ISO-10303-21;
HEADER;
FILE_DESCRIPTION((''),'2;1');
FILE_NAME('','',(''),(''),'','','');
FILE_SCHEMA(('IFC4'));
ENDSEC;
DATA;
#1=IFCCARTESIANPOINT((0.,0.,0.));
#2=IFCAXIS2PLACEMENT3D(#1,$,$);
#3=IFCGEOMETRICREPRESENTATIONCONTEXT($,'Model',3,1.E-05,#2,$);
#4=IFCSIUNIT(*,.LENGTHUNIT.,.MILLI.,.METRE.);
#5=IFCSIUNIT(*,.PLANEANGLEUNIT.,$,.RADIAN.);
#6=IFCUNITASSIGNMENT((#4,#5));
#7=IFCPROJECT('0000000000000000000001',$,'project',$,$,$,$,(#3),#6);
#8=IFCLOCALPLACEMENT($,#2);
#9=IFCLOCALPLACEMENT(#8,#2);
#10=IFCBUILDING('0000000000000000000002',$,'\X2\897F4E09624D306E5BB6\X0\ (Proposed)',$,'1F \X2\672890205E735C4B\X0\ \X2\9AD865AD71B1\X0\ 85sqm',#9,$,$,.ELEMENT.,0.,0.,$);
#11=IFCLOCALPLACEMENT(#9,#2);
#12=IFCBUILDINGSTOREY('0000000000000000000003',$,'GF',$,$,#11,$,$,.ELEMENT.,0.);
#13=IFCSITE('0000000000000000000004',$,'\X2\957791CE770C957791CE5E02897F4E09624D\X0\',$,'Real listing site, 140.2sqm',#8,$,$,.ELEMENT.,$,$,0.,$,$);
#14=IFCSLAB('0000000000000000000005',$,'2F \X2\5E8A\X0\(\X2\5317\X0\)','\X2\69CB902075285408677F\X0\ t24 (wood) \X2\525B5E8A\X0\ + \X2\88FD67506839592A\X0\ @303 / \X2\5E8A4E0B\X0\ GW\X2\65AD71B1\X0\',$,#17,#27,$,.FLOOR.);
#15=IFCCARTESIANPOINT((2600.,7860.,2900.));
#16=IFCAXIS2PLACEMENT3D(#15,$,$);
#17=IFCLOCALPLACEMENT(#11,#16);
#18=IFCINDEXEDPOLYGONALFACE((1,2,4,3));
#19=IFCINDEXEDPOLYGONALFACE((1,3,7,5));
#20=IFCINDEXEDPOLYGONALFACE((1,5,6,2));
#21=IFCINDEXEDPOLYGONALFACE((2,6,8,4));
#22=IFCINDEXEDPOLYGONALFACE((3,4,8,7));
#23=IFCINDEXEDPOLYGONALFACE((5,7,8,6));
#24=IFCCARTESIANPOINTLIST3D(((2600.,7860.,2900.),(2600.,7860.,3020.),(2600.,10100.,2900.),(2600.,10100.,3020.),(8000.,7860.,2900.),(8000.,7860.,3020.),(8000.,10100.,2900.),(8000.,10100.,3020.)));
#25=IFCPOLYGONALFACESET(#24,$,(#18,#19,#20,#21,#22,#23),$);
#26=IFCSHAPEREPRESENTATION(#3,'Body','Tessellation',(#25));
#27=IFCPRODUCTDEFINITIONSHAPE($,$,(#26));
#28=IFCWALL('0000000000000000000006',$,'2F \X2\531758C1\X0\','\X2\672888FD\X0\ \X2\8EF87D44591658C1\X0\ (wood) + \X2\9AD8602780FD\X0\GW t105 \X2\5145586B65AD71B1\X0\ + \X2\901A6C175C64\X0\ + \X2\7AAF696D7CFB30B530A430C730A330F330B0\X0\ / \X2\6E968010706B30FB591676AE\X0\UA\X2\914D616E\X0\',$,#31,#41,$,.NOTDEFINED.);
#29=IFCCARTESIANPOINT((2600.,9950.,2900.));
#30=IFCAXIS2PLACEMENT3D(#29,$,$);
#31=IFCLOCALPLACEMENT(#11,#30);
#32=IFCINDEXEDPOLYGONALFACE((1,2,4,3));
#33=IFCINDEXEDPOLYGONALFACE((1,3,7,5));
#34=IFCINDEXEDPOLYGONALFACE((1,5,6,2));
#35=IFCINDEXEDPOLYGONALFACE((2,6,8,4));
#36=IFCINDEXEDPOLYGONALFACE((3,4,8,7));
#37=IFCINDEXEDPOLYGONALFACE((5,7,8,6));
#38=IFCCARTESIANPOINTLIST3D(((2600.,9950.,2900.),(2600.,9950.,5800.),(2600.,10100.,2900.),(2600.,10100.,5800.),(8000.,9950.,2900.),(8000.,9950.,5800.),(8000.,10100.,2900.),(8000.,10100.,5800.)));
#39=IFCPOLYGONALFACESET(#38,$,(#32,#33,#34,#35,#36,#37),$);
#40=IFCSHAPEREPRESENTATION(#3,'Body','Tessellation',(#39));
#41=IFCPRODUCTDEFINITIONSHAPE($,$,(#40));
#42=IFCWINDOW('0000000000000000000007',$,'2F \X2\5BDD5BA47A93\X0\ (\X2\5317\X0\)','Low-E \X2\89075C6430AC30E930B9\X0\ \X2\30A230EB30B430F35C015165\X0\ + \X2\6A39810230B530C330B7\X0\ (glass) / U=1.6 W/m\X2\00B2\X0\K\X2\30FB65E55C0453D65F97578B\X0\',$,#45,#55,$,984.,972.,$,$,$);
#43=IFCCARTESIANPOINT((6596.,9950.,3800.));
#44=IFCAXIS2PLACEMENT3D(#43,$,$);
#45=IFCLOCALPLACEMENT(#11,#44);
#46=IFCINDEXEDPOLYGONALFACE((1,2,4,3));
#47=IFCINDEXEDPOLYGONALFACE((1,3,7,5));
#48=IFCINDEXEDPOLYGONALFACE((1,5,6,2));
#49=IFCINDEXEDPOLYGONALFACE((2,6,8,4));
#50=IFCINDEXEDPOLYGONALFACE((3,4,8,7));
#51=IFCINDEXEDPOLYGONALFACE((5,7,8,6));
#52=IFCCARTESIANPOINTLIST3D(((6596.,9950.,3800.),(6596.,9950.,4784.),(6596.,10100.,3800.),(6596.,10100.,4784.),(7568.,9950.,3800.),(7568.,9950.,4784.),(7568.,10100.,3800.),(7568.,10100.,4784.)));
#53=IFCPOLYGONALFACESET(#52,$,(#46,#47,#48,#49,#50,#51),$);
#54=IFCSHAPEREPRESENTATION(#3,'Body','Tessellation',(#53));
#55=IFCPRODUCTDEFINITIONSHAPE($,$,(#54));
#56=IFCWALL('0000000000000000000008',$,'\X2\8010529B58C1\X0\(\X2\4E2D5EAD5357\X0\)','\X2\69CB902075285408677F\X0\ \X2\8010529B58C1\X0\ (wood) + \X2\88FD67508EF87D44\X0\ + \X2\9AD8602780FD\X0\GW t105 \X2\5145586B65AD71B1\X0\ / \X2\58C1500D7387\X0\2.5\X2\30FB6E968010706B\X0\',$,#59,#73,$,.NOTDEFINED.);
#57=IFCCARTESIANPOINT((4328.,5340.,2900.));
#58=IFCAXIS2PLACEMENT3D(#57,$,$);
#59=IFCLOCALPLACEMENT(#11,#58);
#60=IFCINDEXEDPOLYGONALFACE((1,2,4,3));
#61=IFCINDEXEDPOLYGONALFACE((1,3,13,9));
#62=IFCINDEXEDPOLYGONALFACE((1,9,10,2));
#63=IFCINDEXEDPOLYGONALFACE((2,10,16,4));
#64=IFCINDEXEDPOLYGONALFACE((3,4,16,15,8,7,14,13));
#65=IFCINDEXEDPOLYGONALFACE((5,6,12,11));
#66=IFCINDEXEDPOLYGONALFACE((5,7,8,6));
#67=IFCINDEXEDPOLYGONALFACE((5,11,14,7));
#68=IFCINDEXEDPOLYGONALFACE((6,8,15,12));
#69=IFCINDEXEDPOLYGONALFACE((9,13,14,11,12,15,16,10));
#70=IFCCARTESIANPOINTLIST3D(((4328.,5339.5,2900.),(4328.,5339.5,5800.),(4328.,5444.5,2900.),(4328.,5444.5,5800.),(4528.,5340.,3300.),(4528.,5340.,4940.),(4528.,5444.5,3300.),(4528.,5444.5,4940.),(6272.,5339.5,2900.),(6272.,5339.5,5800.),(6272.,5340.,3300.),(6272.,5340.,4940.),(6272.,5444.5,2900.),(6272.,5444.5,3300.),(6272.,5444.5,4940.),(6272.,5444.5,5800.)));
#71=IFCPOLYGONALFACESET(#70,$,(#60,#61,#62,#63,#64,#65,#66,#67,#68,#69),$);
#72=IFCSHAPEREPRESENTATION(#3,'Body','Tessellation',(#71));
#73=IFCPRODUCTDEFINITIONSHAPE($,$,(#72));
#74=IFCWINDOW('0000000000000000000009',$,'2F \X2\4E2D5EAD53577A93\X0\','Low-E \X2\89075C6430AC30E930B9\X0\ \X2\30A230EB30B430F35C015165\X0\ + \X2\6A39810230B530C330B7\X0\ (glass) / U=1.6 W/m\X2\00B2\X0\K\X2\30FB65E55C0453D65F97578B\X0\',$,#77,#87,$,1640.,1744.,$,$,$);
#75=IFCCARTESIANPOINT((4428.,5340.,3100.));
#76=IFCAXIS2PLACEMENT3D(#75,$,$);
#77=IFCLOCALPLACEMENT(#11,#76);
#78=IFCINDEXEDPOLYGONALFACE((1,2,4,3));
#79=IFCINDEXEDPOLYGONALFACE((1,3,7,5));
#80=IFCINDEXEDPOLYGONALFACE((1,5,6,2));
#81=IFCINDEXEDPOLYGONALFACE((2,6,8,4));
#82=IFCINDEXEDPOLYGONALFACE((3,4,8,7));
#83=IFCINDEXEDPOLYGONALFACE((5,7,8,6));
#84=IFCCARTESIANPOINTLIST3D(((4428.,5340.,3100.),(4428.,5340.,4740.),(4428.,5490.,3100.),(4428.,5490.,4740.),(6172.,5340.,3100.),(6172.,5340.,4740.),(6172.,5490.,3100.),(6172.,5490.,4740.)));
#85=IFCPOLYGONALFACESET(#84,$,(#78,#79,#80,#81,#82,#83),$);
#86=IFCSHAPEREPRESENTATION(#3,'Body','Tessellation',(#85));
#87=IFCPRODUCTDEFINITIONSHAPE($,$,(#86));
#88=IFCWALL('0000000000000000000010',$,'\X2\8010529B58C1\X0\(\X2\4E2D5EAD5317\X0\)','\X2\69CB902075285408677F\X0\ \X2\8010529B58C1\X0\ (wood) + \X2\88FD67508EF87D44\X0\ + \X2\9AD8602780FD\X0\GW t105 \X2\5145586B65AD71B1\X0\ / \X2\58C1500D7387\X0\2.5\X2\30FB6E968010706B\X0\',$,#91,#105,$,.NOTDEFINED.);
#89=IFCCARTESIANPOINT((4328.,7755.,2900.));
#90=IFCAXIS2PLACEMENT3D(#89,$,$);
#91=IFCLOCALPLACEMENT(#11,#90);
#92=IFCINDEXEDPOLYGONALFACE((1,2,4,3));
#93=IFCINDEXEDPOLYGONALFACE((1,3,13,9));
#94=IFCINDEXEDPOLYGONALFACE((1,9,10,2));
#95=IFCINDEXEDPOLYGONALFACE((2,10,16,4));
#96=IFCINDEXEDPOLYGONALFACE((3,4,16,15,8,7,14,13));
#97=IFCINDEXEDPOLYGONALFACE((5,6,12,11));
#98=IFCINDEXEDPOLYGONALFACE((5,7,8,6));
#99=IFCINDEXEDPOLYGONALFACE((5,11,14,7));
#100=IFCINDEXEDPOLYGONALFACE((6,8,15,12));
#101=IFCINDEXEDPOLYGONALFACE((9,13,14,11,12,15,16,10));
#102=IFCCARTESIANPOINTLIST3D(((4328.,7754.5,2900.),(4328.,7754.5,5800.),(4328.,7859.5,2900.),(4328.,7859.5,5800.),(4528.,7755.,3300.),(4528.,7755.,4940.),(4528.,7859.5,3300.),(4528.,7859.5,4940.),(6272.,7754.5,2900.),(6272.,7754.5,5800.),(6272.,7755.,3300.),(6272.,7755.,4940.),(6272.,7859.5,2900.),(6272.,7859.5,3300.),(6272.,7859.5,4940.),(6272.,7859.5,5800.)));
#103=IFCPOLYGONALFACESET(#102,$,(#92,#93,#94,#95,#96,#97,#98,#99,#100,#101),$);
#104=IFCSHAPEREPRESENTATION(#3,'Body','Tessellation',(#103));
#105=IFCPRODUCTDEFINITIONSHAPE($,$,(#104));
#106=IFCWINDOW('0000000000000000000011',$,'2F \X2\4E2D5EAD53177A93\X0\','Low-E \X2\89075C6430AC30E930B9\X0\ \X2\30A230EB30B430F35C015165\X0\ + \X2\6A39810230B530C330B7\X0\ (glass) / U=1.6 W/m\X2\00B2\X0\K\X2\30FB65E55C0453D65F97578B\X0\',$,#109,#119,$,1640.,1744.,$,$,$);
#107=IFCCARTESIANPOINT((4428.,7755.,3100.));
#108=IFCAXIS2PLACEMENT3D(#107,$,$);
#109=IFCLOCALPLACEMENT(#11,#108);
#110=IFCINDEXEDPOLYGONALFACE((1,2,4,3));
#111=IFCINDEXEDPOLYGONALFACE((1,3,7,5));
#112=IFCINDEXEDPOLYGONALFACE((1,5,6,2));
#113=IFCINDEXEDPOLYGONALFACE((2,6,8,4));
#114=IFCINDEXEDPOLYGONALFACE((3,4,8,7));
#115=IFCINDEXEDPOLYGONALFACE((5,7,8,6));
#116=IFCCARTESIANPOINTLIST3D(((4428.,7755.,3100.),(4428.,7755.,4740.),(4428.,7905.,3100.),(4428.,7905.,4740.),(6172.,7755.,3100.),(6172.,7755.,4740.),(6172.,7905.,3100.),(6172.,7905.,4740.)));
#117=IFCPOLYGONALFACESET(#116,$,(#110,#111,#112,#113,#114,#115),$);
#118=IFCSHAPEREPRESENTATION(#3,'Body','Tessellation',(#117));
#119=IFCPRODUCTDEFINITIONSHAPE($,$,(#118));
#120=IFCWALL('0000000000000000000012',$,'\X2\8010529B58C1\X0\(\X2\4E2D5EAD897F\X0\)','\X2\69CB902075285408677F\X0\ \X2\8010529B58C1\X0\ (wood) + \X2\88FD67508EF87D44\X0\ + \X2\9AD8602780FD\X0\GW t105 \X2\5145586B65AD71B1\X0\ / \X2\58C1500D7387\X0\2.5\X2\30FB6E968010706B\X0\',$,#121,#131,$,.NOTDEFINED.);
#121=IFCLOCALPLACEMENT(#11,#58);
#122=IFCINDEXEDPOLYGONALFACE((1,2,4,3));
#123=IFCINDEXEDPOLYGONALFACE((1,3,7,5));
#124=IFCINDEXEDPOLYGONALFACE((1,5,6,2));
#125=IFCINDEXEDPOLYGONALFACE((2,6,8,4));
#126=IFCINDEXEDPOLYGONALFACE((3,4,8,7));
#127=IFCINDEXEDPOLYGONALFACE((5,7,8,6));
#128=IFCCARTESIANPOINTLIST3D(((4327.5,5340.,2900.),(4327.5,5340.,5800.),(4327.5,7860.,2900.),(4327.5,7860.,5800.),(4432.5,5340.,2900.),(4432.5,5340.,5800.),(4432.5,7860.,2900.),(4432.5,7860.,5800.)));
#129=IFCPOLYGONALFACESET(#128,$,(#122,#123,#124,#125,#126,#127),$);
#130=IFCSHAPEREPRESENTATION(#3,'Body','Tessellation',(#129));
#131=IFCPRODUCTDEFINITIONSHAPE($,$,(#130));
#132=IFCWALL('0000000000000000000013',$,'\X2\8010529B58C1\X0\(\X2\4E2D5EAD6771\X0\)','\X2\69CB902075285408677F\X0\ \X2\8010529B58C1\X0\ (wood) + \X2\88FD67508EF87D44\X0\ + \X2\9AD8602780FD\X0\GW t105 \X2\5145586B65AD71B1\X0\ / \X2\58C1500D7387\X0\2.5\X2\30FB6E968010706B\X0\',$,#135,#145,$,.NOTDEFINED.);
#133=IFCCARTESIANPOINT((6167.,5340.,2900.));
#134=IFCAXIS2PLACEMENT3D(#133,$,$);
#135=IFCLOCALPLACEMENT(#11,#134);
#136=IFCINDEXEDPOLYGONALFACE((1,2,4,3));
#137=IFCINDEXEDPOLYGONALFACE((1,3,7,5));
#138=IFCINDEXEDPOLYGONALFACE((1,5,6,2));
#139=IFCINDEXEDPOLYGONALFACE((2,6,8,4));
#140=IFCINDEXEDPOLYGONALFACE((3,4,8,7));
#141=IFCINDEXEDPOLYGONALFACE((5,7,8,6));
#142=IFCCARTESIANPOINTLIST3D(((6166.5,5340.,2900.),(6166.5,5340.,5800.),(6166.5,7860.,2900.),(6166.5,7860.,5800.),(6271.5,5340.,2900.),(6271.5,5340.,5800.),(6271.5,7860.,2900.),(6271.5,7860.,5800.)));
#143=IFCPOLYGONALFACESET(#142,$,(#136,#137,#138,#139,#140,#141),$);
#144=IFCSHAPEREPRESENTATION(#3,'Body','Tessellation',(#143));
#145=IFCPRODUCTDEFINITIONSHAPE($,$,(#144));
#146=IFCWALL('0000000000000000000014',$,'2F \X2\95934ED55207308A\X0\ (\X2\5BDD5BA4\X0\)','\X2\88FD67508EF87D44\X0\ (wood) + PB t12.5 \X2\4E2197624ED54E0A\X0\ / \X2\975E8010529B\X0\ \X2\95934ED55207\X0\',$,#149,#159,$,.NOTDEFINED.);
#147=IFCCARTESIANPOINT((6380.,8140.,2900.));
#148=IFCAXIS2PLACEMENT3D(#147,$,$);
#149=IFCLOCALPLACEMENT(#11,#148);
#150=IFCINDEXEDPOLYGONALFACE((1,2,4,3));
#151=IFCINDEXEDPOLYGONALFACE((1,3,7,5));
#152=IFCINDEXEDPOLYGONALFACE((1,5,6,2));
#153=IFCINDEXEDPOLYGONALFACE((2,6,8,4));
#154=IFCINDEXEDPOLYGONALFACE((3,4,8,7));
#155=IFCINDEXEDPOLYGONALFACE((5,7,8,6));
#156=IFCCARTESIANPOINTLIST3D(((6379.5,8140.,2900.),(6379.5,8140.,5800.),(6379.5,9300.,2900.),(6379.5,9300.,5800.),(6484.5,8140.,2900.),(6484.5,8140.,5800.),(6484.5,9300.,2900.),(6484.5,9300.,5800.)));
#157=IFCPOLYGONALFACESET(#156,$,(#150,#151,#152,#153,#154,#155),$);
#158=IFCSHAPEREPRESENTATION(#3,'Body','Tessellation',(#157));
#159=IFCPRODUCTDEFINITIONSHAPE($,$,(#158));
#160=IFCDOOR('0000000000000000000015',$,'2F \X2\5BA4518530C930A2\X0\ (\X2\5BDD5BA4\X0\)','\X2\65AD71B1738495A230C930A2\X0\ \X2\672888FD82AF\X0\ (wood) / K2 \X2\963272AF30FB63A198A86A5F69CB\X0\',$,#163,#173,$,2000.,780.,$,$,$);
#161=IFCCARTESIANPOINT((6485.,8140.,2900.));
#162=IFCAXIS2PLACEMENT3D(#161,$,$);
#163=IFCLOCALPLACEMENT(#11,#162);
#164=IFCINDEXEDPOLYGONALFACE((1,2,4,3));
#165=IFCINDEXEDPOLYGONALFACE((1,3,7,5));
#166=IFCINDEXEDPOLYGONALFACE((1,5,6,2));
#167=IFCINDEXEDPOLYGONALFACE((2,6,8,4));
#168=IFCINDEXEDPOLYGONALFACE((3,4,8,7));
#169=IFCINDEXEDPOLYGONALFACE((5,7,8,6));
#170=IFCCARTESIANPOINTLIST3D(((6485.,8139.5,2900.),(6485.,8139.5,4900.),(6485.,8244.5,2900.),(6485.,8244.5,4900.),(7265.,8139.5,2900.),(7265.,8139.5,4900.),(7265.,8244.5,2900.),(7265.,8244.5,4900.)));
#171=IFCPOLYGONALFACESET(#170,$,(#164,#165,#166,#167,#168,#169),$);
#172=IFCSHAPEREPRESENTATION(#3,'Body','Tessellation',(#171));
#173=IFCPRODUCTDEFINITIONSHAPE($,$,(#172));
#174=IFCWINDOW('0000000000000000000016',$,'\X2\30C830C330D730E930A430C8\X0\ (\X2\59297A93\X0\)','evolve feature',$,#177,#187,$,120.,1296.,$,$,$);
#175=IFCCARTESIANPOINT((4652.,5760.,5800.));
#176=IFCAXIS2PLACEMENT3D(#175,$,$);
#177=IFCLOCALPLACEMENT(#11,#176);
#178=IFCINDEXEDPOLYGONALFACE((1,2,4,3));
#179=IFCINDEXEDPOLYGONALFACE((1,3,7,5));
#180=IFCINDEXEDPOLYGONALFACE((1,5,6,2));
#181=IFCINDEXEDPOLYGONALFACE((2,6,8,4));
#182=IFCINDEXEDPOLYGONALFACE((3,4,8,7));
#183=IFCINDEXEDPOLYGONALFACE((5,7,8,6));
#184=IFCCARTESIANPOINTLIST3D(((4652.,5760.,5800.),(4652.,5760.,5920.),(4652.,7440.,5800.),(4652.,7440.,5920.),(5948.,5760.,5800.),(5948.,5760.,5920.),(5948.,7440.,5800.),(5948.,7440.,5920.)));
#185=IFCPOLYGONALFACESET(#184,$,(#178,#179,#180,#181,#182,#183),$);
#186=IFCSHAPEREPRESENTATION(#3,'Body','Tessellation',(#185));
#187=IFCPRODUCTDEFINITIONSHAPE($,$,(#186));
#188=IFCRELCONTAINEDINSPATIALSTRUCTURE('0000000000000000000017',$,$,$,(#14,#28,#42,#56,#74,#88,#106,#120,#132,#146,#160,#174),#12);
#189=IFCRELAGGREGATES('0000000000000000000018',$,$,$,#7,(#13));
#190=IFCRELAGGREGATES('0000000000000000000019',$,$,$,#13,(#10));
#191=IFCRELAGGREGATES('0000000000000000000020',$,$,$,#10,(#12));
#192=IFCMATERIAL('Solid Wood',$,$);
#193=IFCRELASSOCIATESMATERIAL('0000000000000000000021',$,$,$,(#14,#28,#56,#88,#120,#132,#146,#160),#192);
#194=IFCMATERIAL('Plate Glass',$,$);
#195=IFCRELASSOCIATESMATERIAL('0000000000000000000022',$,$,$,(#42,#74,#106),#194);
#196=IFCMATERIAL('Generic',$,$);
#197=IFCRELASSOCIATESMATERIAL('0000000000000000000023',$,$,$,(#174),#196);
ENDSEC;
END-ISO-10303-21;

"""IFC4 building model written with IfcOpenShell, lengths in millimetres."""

from ifc_helpers import new_model, si_unit, frame, frame_2d, origin, place, context, project, spatial, rectangle, extrude, material, element, fill, save


model = new_model("IFC4")

# Units and contexts
model_context = context("Model", 3, precision=1e-05, world=origin())
ifc_project = project(units=[si_unit("LENGTHUNIT", "METRE", prefix="MILLI"), si_unit("PLANEANGLEUNIT", "RADIAN")], contexts=[model_context])

# Site, building, storey
site_placement = place(None, origin())
site = spatial("IfcSite", under=ifc_project, at=site_placement, Name="長野県長野市西三才", ObjectType="Real listing site, 140.2sqm", CompositionType="ELEMENT", RefElevation=0.0)
building_placement = place(site_placement, origin())
building = spatial("IfcBuilding", under=site, at=building_placement, Name="西三才の家 (Proposed)", ObjectType="1F 木造平屋 高断熱 85sqm", CompositionType="ELEMENT", ElevationOfRefHeight=0.0, ElevationOfTerrain=0.0)
storey_placement = place(building_placement, origin())
storey = spatial("IfcBuildingStorey", under=building, at=storey_placement, Name="GF", CompositionType="ELEMENT", Elevation=0.0)

# Slab
ifc_material_1 = material(Name="Solid Wood")
slab_placement = place(storey_placement, frame((2600.0, 7860.0, 2900.0)))
element("IfcSlab", 1, at=slab_placement, inside=storey, material=ifc_material_1, Name="2F 床(北)", Description="構造用合板 t24 (wood) 剛床 + 製材根太 @303 / 床下 GW断熱", PredefinedType="FLOOR", context=model_context, shape_type="SweptSolid", body=[
    extrude(rectangle(XDim=5400.0, YDim=2240.0, at=frame_2d((2700.0, 1120.0))), frame((2600.0, 7860.0, 2900.0)), (0.0, 0.0, 1.0), 120.0),
])

# Walls, openings, windows
wall_1_placement = place(storey_placement, frame((2600.0, 9950.0, 2900.0)))
wall_1 = element("IfcWall", 2, at=wall_1_placement, inside=storey, material=ifc_material_1, Name="2F 北壁", Description="木製 軸組外壁 (wood) + 高性能GW t105 充填断熱 + 通気層 + 窯業系サイディング / 準耐火・外皮UA配慮", PredefinedType="NOTDEFINED", context=model_context, shape_type="SweptSolid", body=[
    extrude(rectangle(XDim=5400.0, YDim=150.0, at=frame_2d((2700.0, 75.0))), frame((2600.0, 9950.0, 2900.0)), (0.0, 0.0, 1.0), 2900.0),
])
opening_1_placement = place(storey_placement, frame((6596.0, 9950.0, 3800.0)))
opening_1 = element("IfcOpeningElement", 3, at=opening_1_placement, cuts=wall_1, PredefinedType="NOTDEFINED", context=model_context, shape_type="SweptSolid", body=[
    extrude(rectangle(XDim=972.0, YDim=150.0, at=frame_2d((486.0, 75.0))), frame((6596.0, 9950.0, 3800.0)), (0.0, 0.0, 1.0), 984.0),
])
ifc_material_2 = material(Name="Plate Glass")
window_1_placement = place(storey_placement, frame((6596.0, 9950.0, 3800.0)))
window_1 = element("IfcWindow", 4, at=window_1_placement, inside=storey, material=ifc_material_2, Name="2F 寝室窓 (北)", Description="Low-E 複層ガラス アルゴン封入 + 樹脂サッシ (glass) / U=1.6 W/m²K・日射取得型", OverallHeight=984.0, OverallWidth=972.0, context=model_context, shape_type="SweptSolid", body=[
    extrude(rectangle(XDim=972.0, YDim=150.0, at=frame_2d((486.0, 75.0))), frame((6596.0, 9950.0, 3800.0)), (0.0, 0.0, 1.0), 984.0),
])
fill(opening_1, window_1)
wall_2_placement = place(storey_placement, frame((4328.0, 5340.0, 2900.0)))
wall_2 = element("IfcWall", 5, at=wall_2_placement, inside=storey, material=ifc_material_1, Name="耐力壁(中庭南)", Description="構造用合板 耐力壁 (wood) + 製材軸組 + 高性能GW t105 充填断熱 / 壁倍率2.5・準耐火", PredefinedType="NOTDEFINED", context=model_context, shape_type="SweptSolid", body=[
    extrude(rectangle(XDim=1944.0, YDim=105.0, at=frame_2d((972.0, 52.0))), frame((4328.0, 5340.0, 2900.0)), (0.0, 0.0, 1.0), 2900.0),
])
opening_2_placement = place(storey_placement, frame((4428.0, 5340.0, 3100.0)))
opening_2 = element("IfcOpeningElement", 6, at=opening_2_placement, cuts=wall_2, PredefinedType="NOTDEFINED", context=model_context, shape_type="SweptSolid", body=[
    extrude(rectangle(XDim=1744.0, YDim=150.0, at=frame_2d((872.0, 75.0))), frame((4428.0, 5340.0, 3100.0)), (0.0, 0.0, 1.0), 1640.0),
])
window_2_placement = place(storey_placement, frame((4428.0, 5340.0, 3100.0)))
window_2 = element("IfcWindow", 7, at=window_2_placement, inside=storey, material=ifc_material_2, Name="2F 中庭南窓", Description="Low-E 複層ガラス アルゴン封入 + 樹脂サッシ (glass) / U=1.6 W/m²K・日射取得型", OverallHeight=1640.0, OverallWidth=1744.0, context=model_context, shape_type="SweptSolid", body=[
    extrude(rectangle(XDim=1744.0, YDim=150.0, at=frame_2d((872.0, 75.0))), frame((4428.0, 5340.0, 3100.0)), (0.0, 0.0, 1.0), 1640.0),
])
fill(opening_2, window_2)
wall_3_placement = place(storey_placement, frame((4328.0, 7755.0, 2900.0)))
wall_3 = element("IfcWall", 8, at=wall_3_placement, inside=storey, material=ifc_material_1, Name="耐力壁(中庭北)", Description="構造用合板 耐力壁 (wood) + 製材軸組 + 高性能GW t105 充填断熱 / 壁倍率2.5・準耐火", PredefinedType="NOTDEFINED", context=model_context, shape_type="SweptSolid", body=[
    extrude(rectangle(XDim=1944.0, YDim=105.0, at=frame_2d((972.0, 52.0))), frame((4328.0, 7755.0, 2900.0)), (0.0, 0.0, 1.0), 2900.0),
])
opening_3_placement = place(storey_placement, frame((4428.0, 7755.0, 3100.0)))
opening_3 = element("IfcOpeningElement", 9, at=opening_3_placement, cuts=wall_3, PredefinedType="NOTDEFINED", context=model_context, shape_type="SweptSolid", body=[
    extrude(rectangle(XDim=1744.0, YDim=150.0, at=frame_2d((872.0, 75.0))), frame((4428.0, 7755.0, 3100.0)), (0.0, 0.0, 1.0), 1640.0),
])
window_3_placement = place(storey_placement, frame((4428.0, 7755.0, 3100.0)))
window_3 = element("IfcWindow", 10, at=window_3_placement, inside=storey, material=ifc_material_2, Name="2F 中庭北窓", Description="Low-E 複層ガラス アルゴン封入 + 樹脂サッシ (glass) / U=1.6 W/m²K・日射取得型", OverallHeight=1640.0, OverallWidth=1744.0, context=model_context, shape_type="SweptSolid", body=[
    extrude(rectangle(XDim=1744.0, YDim=150.0, at=frame_2d((872.0, 75.0))), frame((4428.0, 7755.0, 3100.0)), (0.0, 0.0, 1.0), 1640.0),
])
fill(opening_3, window_3)

# Walls
wall_4_placement = place(storey_placement, frame((4328.0, 5340.0, 2900.0)))
element("IfcWall", 11, at=wall_4_placement, inside=storey, material=ifc_material_1, Name="耐力壁(中庭西)", Description="構造用合板 耐力壁 (wood) + 製材軸組 + 高性能GW t105 充填断熱 / 壁倍率2.5・準耐火", PredefinedType="NOTDEFINED", context=model_context, shape_type="SweptSolid", body=[
    extrude(rectangle(XDim=105.0, YDim=2520.0, at=frame_2d((52.0, 1260.0))), frame((4328.0, 5340.0, 2900.0)), (0.0, 0.0, 1.0), 2900.0),
])
wall_5_placement = place(storey_placement, frame((6167.0, 5340.0, 2900.0)))
element("IfcWall", 12, at=wall_5_placement, inside=storey, material=ifc_material_1, Name="耐力壁(中庭東)", Description="構造用合板 耐力壁 (wood) + 製材軸組 + 高性能GW t105 充填断熱 / 壁倍率2.5・準耐火", PredefinedType="NOTDEFINED", context=model_context, shape_type="SweptSolid", body=[
    extrude(rectangle(XDim=105.0, YDim=2520.0, at=frame_2d((52.0, 1260.0))), frame((6167.0, 5340.0, 2900.0)), (0.0, 0.0, 1.0), 2900.0),
])
wall_6_placement = place(storey_placement, frame((6380.0, 8140.0, 2900.0)))
element("IfcWall", 13, at=wall_6_placement, inside=storey, material=ifc_material_1, Name="2F 間仕切り (寝室)", Description="製材軸組 (wood) + PB t12.5 両面仕上 / 非耐力 間仕切", PredefinedType="NOTDEFINED", context=model_context, shape_type="SweptSolid", body=[
    extrude(rectangle(XDim=105.0, YDim=1160.0, at=frame_2d((52.0, 580.0))), frame((6380.0, 8140.0, 2900.0)), (0.0, 0.0, 1.0), 2900.0),
])

# Door
door_placement = place(storey_placement, frame((6485.0, 8140.0, 2900.0)))
element("IfcDoor", 14, at=door_placement, inside=storey, material=ifc_material_1, Name="2F 室内ドア (寝室)", Description="断熱玄関ドア 木製芯 (wood) / K2 防犯・採風機構", OverallHeight=2000.0, OverallWidth=780.0, context=model_context, shape_type="SweptSolid", body=[
    extrude(rectangle(XDim=780.0, YDim=105.0, at=frame_2d((390.0, 52.0))), frame((6485.0, 8140.0, 2900.0)), (0.0, 0.0, 1.0), 2000.0),
])

# Window
ifc_material_3 = material(Name="Generic")
window_4_placement = place(storey_placement, frame((4652.0, 5760.0, 5800.0)))
element("IfcWindow", 15, at=window_4_placement, inside=storey, material=ifc_material_3, Name="トップライト (天窓)", Description="evolve feature", OverallHeight=120.0, OverallWidth=1296.0, context=model_context, shape_type="SweptSolid", body=[
    extrude(rectangle(XDim=1296.0, YDim=1680.0, at=frame_2d((648.0, 840.0))), frame((4652.0, 5760.0, 5800.0)), (0.0, 0.0, 1.0), 120.0),
])

save(model, "model.ifc")
